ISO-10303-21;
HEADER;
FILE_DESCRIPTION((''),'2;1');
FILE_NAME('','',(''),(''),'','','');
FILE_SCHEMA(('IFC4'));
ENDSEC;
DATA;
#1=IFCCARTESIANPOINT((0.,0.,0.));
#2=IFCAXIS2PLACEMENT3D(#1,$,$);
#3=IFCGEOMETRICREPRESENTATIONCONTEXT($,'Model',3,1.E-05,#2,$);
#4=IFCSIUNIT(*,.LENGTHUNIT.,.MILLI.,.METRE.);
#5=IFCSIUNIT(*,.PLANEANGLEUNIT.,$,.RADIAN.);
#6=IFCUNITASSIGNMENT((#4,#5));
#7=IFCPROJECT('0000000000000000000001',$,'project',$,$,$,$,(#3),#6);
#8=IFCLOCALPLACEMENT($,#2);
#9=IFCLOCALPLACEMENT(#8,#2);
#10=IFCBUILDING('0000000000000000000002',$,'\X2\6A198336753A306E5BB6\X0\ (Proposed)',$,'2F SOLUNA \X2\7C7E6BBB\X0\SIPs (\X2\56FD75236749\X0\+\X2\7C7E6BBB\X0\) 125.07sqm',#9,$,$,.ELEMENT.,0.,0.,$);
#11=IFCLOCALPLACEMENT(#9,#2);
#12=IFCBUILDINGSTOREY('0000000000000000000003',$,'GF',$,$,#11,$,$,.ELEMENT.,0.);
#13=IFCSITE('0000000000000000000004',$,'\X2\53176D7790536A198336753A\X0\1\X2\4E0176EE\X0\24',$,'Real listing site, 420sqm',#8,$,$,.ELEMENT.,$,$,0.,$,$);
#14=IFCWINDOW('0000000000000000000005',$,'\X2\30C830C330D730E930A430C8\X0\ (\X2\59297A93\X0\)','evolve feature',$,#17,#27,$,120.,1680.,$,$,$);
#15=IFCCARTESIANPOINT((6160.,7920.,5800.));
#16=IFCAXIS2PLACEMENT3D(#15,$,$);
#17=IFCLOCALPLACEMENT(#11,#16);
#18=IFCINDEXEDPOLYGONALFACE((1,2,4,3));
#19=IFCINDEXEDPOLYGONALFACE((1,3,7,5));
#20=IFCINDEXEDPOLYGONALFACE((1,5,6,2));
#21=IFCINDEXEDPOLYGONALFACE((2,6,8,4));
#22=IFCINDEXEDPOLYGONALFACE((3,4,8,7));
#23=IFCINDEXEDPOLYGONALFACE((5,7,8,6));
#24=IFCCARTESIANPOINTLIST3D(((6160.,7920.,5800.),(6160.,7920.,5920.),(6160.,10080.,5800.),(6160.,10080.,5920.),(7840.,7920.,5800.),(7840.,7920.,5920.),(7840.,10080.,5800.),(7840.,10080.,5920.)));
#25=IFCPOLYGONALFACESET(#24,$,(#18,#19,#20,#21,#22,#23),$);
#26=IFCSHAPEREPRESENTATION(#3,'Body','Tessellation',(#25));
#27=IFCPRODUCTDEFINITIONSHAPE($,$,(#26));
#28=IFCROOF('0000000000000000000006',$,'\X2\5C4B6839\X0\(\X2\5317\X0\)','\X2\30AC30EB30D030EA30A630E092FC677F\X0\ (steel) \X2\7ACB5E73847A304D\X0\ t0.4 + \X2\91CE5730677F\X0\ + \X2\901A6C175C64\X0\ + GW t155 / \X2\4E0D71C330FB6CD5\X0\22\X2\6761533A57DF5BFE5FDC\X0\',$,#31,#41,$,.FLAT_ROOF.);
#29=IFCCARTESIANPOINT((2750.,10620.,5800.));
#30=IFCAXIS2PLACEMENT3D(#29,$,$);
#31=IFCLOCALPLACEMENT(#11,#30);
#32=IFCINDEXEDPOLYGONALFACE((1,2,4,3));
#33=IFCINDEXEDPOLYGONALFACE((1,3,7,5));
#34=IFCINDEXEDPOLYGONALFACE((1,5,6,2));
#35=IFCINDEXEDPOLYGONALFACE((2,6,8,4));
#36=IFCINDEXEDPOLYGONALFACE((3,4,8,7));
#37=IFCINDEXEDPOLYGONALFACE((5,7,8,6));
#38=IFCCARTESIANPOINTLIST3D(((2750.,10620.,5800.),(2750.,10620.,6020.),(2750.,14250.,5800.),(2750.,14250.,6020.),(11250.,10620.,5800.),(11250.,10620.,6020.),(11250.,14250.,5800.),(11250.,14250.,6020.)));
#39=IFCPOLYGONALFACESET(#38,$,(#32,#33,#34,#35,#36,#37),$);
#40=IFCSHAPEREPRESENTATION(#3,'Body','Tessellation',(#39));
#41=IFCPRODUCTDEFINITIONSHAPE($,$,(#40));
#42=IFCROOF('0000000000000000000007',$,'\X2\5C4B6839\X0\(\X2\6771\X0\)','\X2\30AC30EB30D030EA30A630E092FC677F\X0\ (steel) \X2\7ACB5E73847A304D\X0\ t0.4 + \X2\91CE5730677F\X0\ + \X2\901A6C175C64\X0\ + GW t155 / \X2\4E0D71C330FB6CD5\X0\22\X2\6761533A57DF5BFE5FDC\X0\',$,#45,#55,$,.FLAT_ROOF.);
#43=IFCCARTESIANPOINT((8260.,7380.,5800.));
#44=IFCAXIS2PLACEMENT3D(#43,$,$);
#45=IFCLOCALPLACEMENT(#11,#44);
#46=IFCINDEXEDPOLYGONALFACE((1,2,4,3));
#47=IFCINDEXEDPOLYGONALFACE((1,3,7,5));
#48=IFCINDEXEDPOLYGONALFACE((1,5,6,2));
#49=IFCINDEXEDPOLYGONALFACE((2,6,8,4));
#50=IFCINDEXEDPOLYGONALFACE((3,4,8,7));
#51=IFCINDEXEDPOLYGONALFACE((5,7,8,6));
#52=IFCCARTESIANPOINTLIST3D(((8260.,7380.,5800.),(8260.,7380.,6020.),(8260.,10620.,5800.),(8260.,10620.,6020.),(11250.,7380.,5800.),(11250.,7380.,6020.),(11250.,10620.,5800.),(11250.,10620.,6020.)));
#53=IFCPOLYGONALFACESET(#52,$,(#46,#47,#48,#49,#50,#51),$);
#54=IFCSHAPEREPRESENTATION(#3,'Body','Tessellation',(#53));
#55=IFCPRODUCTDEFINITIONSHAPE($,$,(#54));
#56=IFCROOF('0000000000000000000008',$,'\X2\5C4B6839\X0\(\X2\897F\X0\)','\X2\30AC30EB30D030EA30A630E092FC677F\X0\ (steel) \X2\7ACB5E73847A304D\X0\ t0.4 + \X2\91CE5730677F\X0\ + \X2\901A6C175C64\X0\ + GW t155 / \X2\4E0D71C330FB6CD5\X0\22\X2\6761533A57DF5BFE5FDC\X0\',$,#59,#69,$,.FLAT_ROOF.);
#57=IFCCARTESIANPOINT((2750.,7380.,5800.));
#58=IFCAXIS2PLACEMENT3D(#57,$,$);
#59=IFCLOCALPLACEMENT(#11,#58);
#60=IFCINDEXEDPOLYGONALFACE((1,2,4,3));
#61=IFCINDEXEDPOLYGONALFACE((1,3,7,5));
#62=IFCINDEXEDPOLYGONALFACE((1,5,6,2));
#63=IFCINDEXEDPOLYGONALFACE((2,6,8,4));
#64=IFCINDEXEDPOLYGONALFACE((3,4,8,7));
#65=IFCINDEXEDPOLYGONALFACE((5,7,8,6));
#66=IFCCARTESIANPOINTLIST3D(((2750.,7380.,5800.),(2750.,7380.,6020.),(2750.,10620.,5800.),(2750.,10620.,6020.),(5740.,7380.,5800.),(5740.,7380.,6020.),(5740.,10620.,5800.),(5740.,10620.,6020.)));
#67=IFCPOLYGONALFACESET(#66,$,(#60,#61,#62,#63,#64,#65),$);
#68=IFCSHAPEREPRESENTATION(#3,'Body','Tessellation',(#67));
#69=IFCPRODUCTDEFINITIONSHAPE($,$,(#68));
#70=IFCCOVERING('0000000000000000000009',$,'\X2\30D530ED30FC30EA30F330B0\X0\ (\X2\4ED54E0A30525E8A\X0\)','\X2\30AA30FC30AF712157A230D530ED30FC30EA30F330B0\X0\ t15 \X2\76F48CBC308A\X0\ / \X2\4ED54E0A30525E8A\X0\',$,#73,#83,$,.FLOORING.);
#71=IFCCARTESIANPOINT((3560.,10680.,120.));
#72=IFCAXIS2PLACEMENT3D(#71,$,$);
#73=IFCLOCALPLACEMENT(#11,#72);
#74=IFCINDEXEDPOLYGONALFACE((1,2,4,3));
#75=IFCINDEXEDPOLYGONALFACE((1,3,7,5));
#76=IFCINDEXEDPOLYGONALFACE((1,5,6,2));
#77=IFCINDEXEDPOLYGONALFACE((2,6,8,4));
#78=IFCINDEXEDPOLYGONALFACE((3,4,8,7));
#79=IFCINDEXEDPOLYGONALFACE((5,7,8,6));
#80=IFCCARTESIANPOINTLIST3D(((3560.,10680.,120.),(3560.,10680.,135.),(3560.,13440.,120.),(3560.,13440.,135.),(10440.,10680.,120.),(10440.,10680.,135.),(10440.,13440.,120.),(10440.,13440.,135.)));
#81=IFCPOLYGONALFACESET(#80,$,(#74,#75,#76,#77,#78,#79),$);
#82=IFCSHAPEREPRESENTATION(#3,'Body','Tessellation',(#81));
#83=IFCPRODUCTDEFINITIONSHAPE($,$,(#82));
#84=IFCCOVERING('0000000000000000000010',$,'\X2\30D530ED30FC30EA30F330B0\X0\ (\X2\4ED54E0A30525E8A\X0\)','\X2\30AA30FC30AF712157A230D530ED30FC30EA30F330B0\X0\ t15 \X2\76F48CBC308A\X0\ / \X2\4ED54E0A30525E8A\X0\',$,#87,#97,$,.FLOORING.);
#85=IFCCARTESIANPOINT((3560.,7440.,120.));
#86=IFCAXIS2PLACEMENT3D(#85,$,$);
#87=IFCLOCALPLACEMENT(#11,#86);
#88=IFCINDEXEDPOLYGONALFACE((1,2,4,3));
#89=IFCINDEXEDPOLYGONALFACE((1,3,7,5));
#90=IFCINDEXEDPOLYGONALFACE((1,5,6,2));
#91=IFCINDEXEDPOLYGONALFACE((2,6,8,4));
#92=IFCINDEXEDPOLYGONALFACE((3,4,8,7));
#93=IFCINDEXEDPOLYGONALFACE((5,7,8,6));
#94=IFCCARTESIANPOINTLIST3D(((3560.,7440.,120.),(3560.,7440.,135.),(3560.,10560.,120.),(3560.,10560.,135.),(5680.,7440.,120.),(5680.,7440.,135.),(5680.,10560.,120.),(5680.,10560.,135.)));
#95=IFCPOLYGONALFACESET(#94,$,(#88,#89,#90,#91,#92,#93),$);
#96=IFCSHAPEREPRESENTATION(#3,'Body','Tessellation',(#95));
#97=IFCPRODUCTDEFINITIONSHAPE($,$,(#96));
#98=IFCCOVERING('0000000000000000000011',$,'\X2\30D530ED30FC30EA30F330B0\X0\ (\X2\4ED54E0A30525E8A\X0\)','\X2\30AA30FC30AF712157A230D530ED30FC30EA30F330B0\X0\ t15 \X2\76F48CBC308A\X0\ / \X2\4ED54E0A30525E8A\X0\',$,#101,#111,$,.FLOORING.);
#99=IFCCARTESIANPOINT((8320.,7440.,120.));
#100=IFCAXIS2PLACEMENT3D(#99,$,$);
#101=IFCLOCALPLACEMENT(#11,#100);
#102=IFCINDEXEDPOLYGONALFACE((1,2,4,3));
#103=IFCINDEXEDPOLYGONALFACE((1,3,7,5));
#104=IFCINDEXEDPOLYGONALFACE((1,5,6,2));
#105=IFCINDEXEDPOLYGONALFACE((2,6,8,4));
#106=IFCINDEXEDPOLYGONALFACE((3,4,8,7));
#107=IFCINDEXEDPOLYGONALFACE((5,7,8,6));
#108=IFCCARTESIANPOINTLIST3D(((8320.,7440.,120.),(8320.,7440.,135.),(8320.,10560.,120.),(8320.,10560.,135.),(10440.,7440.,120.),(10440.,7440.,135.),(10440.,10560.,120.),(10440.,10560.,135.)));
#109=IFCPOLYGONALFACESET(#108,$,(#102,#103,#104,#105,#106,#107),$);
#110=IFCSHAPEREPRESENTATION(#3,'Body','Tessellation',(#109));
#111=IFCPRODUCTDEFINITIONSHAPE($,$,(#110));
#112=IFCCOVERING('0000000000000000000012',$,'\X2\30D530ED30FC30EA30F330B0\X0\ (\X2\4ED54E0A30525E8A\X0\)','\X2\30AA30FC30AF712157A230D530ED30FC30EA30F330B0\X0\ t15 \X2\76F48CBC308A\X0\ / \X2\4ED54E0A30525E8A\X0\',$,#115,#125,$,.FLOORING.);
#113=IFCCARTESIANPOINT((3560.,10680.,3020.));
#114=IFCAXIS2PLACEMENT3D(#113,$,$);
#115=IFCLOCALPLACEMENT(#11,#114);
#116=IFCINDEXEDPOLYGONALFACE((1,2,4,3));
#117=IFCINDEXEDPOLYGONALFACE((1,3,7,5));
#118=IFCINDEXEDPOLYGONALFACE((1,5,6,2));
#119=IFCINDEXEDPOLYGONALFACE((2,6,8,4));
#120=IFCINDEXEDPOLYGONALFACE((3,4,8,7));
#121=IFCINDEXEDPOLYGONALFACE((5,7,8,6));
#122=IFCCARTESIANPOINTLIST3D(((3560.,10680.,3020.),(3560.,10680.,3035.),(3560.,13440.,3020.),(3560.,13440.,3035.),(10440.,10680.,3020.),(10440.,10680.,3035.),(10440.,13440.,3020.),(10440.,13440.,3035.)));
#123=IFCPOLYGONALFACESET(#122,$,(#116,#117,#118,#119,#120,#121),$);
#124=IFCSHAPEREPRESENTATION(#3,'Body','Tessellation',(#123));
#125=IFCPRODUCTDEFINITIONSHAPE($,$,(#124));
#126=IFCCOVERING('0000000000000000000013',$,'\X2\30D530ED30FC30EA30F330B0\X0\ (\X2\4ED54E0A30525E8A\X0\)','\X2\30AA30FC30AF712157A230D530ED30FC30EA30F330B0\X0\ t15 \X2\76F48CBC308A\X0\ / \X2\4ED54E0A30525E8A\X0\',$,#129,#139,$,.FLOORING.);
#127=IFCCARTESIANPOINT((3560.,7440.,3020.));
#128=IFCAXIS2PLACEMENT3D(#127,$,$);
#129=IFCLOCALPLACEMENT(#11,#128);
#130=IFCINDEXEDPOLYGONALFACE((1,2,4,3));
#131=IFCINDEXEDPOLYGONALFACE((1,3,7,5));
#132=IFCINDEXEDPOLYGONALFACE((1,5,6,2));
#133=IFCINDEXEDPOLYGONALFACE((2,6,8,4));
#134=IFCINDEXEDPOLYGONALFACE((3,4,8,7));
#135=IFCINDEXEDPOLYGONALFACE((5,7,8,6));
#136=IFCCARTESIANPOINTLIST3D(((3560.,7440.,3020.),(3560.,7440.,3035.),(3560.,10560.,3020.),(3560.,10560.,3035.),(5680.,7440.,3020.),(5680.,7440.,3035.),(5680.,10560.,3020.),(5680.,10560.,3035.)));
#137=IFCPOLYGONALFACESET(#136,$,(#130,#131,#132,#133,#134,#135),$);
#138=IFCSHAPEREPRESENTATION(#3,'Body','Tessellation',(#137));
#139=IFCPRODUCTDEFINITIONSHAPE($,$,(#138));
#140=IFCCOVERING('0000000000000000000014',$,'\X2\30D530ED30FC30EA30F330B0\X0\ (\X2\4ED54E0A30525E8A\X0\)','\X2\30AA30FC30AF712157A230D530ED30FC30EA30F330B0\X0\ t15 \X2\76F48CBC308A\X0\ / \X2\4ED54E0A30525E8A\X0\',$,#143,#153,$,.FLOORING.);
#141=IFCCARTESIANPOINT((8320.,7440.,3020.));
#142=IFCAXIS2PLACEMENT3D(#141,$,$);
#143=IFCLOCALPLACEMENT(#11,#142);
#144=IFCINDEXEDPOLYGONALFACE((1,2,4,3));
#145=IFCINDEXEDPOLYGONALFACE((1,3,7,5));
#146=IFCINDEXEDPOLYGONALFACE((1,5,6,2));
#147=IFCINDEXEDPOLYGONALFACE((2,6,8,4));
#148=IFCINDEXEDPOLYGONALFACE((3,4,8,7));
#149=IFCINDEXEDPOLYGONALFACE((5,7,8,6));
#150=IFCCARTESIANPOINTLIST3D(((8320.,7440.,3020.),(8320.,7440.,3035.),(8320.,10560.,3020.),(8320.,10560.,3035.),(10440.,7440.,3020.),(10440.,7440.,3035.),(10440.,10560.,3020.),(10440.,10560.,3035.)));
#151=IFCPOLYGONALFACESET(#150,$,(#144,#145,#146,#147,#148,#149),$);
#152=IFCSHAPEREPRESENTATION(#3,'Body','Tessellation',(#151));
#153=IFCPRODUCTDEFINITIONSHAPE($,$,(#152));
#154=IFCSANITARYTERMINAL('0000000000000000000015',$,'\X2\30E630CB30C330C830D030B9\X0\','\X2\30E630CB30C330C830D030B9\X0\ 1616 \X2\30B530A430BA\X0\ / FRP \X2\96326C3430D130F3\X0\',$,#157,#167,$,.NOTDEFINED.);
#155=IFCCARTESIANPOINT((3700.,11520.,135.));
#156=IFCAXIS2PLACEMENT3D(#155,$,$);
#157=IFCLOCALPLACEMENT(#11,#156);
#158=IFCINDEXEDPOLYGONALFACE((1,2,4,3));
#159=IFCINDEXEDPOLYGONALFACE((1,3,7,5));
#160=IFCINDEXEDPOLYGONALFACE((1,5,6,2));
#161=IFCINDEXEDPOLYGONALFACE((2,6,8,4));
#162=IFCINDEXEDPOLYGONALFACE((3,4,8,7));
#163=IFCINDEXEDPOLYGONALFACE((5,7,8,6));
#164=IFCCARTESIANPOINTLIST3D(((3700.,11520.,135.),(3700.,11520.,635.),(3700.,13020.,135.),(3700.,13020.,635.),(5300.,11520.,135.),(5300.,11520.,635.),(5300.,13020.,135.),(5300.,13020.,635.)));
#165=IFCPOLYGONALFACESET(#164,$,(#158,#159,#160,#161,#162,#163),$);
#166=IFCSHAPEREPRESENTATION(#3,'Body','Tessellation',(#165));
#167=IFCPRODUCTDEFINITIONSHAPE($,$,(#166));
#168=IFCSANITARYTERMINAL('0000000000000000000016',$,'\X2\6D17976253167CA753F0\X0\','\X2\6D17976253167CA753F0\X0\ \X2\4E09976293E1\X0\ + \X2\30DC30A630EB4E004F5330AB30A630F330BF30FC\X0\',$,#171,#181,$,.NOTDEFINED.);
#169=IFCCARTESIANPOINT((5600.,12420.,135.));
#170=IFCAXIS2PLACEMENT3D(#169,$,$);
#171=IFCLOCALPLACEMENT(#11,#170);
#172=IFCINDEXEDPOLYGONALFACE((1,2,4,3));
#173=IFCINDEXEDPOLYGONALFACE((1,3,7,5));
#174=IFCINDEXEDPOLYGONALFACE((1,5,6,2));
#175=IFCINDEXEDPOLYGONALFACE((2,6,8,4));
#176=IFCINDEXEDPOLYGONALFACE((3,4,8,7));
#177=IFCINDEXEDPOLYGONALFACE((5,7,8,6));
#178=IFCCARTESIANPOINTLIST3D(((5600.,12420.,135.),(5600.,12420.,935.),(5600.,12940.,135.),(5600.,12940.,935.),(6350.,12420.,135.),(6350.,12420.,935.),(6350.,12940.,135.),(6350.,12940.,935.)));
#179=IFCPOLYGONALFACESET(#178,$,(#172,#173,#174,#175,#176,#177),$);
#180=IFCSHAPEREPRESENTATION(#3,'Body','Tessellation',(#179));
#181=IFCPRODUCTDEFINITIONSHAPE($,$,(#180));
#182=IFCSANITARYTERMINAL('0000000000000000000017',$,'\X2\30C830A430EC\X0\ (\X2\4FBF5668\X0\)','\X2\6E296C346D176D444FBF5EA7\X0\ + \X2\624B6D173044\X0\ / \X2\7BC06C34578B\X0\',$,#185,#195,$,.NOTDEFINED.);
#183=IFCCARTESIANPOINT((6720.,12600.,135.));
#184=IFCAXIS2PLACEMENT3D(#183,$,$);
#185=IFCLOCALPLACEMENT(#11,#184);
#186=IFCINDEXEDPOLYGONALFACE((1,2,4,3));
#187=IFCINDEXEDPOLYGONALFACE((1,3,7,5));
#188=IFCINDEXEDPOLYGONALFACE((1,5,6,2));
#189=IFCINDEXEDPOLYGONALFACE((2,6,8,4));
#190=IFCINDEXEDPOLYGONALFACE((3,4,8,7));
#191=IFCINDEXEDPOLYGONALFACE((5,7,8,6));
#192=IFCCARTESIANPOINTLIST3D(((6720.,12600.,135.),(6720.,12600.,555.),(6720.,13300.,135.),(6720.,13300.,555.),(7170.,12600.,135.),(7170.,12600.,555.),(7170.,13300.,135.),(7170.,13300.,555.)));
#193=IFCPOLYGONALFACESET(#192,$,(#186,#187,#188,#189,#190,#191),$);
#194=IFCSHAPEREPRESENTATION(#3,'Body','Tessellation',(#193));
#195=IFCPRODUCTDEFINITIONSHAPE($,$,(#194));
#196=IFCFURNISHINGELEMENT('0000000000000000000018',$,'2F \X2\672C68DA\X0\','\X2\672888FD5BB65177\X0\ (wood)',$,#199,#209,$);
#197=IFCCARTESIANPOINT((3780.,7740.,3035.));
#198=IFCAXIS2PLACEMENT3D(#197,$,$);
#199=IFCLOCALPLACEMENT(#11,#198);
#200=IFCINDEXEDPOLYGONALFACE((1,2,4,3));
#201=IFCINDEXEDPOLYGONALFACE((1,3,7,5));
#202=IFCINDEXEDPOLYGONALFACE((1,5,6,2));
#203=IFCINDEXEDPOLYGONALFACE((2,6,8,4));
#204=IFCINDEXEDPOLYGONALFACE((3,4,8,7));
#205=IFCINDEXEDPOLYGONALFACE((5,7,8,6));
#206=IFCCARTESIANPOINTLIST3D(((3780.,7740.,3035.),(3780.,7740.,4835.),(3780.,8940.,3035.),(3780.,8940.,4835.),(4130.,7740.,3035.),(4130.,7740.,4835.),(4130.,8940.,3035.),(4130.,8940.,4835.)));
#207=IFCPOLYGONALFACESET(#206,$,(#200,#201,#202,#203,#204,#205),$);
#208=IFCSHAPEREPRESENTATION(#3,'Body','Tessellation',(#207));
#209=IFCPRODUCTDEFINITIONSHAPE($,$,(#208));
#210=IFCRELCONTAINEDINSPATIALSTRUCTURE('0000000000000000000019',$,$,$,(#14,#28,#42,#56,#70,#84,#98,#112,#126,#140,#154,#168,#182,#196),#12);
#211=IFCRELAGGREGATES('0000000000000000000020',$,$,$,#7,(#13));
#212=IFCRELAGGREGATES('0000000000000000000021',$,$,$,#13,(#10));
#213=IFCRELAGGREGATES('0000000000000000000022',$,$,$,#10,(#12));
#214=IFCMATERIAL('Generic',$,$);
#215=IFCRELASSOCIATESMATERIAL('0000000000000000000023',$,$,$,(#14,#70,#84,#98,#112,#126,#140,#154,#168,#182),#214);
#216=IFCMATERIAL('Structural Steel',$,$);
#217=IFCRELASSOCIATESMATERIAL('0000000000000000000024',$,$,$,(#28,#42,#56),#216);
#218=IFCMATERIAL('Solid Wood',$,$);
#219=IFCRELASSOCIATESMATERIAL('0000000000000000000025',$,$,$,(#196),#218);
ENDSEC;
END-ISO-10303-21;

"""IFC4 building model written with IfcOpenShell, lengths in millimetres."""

from ifc_helpers import new_model, si_unit, frame, frame_2d, origin, place, context, project, spatial, rectangle, extrude, material, element, save


model = new_model("IFC4")

# Units and contexts
model_context = context("Model", 3, precision=1e-05, world=origin())
ifc_project = project(units=[si_unit("LENGTHUNIT", "METRE", prefix="MILLI"), si_unit("PLANEANGLEUNIT", "RADIAN")], contexts=[model_context])

# Site, building, storey
site_placement = place(None, origin())
site = spatial("IfcSite", under=ifc_project, at=site_placement, Name="北海道標茶町1丁目24", ObjectType="Real listing site, 420sqm", CompositionType="ELEMENT", RefElevation=0.0)
building_placement = place(site_placement, origin())
building = spatial("IfcBuilding", under=site, at=building_placement, Name="標茶町の家 (Proposed)", ObjectType="2F SOLUNA 籾殻SIPs (国産杉+籾殻) 125.07sqm", CompositionType="ELEMENT", ElevationOfRefHeight=0.0, ElevationOfTerrain=0.0)
storey_placement = place(building_placement, origin())
storey = spatial("IfcBuildingStorey", under=building, at=storey_placement, Name="GF", CompositionType="ELEMENT", Elevation=0.0)

# Shared definitions
ifc_material_1 = material(Name="Solid Wood")

# Window
ifc_material_2 = material(Name="Generic")
window_1_placement = place(storey_placement, frame((6160.0, 7920.0, 5800.0)))
element("IfcWindow", 1, at=window_1_placement, inside=storey, material=ifc_material_2, Name="トップライト (天窓)", Description="evolve feature", OverallHeight=120.0, OverallWidth=1680.0, context=model_context, shape_type="SweptSolid", body=[
    extrude(rectangle(XDim=1680.0, YDim=2160.0, at=frame_2d((840.0, 1080.0))), frame((6160.0, 7920.0, 5800.0)), (0.0, 0.0, 1.0), 120.0),
])

# Roofs
ifc_material_3 = material(Name="Structural Steel")
roof_1_placement = place(storey_placement, frame((2750.0, 10620.0, 5800.0)))
element("IfcRoof", 2, at=roof_1_placement, inside=storey, material=ifc_material_3, Name="屋根(北)", Description="ガルバリウム鋼板 (steel) 立平葺き t0.4 + 野地板 + 通気層 + GW t155 / 不燃・法22条区域対応", PredefinedType="FLAT_ROOF", context=model_context, shape_type="SweptSolid", body=[
    extrude(rectangle(XDim=8500.0, YDim=3630.0, at=frame_2d((4250.0, 1815.0))), frame((2750.0, 10620.0, 5800.0)), (0.0, 0.0, 1.0), 220.0),
])
roof_2_placement = place(storey_placement, frame((8260.0, 7380.0, 5800.0)))
element("IfcRoof", 3, at=roof_2_placement, inside=storey, material=ifc_material_3, Name="屋根(東)", Description="ガルバリウム鋼板 (steel) 立平葺き t0.4 + 野地板 + 通気層 + GW t155 / 不燃・法22条区域対応", PredefinedType="FLAT_ROOF", context=model_context, shape_type="SweptSolid", body=[
    extrude(rectangle(XDim=2990.0, YDim=3240.0, at=frame_2d((1495.0, 1620.0))), frame((8260.0, 7380.0, 5800.0)), (0.0, 0.0, 1.0), 220.0),
])
roof_3_placement = place(storey_placement, frame((2750.0, 7380.0, 5800.0)))
element("IfcRoof", 4, at=roof_3_placement, inside=storey, material=ifc_material_3, Name="屋根(西)", Description="ガルバリウム鋼板 (steel) 立平葺き t0.4 + 野地板 + 通気層 + GW t155 / 不燃・法22条区域対応", PredefinedType="FLAT_ROOF", context=model_context, shape_type="SweptSolid", body=[
    extrude(rectangle(XDim=2990.0, YDim=3240.0, at=frame_2d((1495.0, 1620.0))), frame((2750.0, 7380.0, 5800.0)), (0.0, 0.0, 1.0), 220.0),
])

# Coverings
covering_1_placement = place(storey_placement, frame((3560.0, 10680.0, 120.0)))
element("IfcCovering", 5, at=covering_1_placement, inside=storey, material=ifc_material_2, Name="フローリング (仕上げ床)", Description="オーク無垢フローリング t15 直貼り / 仕上げ床", PredefinedType="FLOORING", context=model_context, shape_type="SweptSolid", body=[
    extrude(rectangle(XDim=6880.0, YDim=2760.0, at=frame_2d((3440.0, 1380.0))), frame((3560.0, 10680.0, 120.0)), (0.0, 0.0, 1.0), 15.0),
])
covering_2_placement = place(storey_placement, frame((3560.0, 7440.0, 120.0)))
element("IfcCovering", 6, at=covering_2_placement, inside=storey, material=ifc_material_2, Name="フローリング (仕上げ床)", Description="オーク無垢フローリング t15 直貼り / 仕上げ床", PredefinedType="FLOORING", context=model_context, shape_type="SweptSolid", body=[
    extrude(rectangle(XDim=2120.0, YDim=3120.0, at=frame_2d((1060.0, 1560.0))), frame((3560.0, 7440.0, 120.0)), (0.0, 0.0, 1.0), 15.0),
])
covering_3_placement = place(storey_placement, frame((8320.0, 7440.0, 120.0)))
element("IfcCovering", 7, at=covering_3_placement, inside=storey, material=ifc_material_2, Name="フローリング (仕上げ床)", Description="オーク無垢フローリング t15 直貼り / 仕上げ床", PredefinedType="FLOORING", context=model_context, shape_type="SweptSolid", body=[
    extrude(rectangle(XDim=2120.0, YDim=3120.0, at=frame_2d((1060.0, 1560.0))), frame((8320.0, 7440.0, 120.0)), (0.0, 0.0, 1.0), 15.0),
])
covering_4_placement = place(storey_placement, frame((3560.0, 10680.0, 3020.0)))
element("IfcCovering", 8, at=covering_4_placement, inside=storey, material=ifc_material_2, Name="フローリング (仕上げ床)", Description="オーク無垢フローリング t15 直貼り / 仕上げ床", PredefinedType="FLOORING", context=model_context, shape_type="SweptSolid", body=[
    extrude(rectangle(XDim=6880.0, YDim=2760.0, at=frame_2d((3440.0, 1380.0))), frame((3560.0, 10680.0, 3020.0)), (0.0, 0.0, 1.0), 15.0),
])
covering_5_placement = place(storey_placement, frame((3560.0, 7440.0, 3020.0)))
element("IfcCovering", 9, at=covering_5_placement, inside=storey, material=ifc_material_2, Name="フローリング (仕上げ床)", Description="オーク無垢フローリング t15 直貼り / 仕上げ床", PredefinedType="FLOORING", context=model_context, shape_type="SweptSolid", body=[
    extrude(rectangle(XDim=2120.0, YDim=3120.0, at=frame_2d((1060.0, 1560.0))), frame((3560.0, 7440.0, 3020.0)), (0.0, 0.0, 1.0), 15.0),
])
covering_6_placement = place(storey_placement, frame((8320.0, 7440.0, 3020.0)))
element("IfcCovering", 10, at=covering_6_placement, inside=storey, material=ifc_material_2, Name="フローリング (仕上げ床)", Description="オーク無垢フローリング t15 直貼り / 仕上げ床", PredefinedType="FLOORING", context=model_context, shape_type="SweptSolid", body=[
    extrude(rectangle(XDim=2120.0, YDim=3120.0, at=frame_2d((1060.0, 1560.0))), frame((8320.0, 7440.0, 3020.0)), (0.0, 0.0, 1.0), 15.0),
])

# Sanitary terminals
sanitary_terminal_1_placement = place(storey_placement, frame((3700.0, 11520.0, 135.0)))
element("IfcSanitaryTerminal", 11, at=sanitary_terminal_1_placement, inside=storey, material=ifc_material_2, Name="ユニットバス", Description="ユニットバス 1616 サイズ / FRP 防水パン", PredefinedType="NOTDEFINED", context=model_context, shape_type="SweptSolid", body=[
    extrude(rectangle(XDim=1600.0, YDim=1500.0, at=frame_2d((800.0, 750.0))), frame((3700.0, 11520.0, 135.0)), (0.0, 0.0, 1.0), 500.0),
])
sanitary_terminal_2_placement = place(storey_placement, frame((5600.0, 12420.0, 135.0)))
element("IfcSanitaryTerminal", 12, at=sanitary_terminal_2_placement, inside=storey, material=ifc_material_2, Name="洗面化粧台", Description="洗面化粧台 三面鏡 + ボウル一体カウンター", PredefinedType="NOTDEFINED", context=model_context, shape_type="SweptSolid", body=[
    extrude(rectangle(XDim=750.0, YDim=520.0, at=frame_2d((375.0, 260.0))), frame((5600.0, 12420.0, 135.0)), (0.0, 0.0, 1.0), 800.0),
])
sanitary_terminal_3_placement = place(storey_placement, frame((6720.0, 12600.0, 135.0)))
element("IfcSanitaryTerminal", 13, at=sanitary_terminal_3_placement, inside=storey, material=ifc_material_2, Name="トイレ (便器)", Description="温水洗浄便座 + 手洗い / 節水型", PredefinedType="NOTDEFINED", context=model_context, shape_type="SweptSolid", body=[
    extrude(rectangle(XDim=450.0, YDim=700.0, at=frame_2d((225.0, 350.0))), frame((6720.0, 12600.0, 135.0)), (0.0, 0.0, 1.0), 420.0),
])

# Furnishing element
furnishing_placement = place(storey_placement, frame((3780.0, 7740.0, 3035.0)))
element("IfcFurnishingElement", 14, at=furnishing_placement, inside=storey, material=ifc_material_1, Name="2F 本棚", Description="木製家具 (wood)", context=model_context, shape_type="SweptSolid", body=[
    extrude(rectangle(XDim=350.0, YDim=1200.0, at=frame_2d((175.0, 600.0))), frame((3780.0, 7740.0, 3035.0)), (0.0, 0.0, 1.0), 1800.0),
])

save(model, "model.ifc")
